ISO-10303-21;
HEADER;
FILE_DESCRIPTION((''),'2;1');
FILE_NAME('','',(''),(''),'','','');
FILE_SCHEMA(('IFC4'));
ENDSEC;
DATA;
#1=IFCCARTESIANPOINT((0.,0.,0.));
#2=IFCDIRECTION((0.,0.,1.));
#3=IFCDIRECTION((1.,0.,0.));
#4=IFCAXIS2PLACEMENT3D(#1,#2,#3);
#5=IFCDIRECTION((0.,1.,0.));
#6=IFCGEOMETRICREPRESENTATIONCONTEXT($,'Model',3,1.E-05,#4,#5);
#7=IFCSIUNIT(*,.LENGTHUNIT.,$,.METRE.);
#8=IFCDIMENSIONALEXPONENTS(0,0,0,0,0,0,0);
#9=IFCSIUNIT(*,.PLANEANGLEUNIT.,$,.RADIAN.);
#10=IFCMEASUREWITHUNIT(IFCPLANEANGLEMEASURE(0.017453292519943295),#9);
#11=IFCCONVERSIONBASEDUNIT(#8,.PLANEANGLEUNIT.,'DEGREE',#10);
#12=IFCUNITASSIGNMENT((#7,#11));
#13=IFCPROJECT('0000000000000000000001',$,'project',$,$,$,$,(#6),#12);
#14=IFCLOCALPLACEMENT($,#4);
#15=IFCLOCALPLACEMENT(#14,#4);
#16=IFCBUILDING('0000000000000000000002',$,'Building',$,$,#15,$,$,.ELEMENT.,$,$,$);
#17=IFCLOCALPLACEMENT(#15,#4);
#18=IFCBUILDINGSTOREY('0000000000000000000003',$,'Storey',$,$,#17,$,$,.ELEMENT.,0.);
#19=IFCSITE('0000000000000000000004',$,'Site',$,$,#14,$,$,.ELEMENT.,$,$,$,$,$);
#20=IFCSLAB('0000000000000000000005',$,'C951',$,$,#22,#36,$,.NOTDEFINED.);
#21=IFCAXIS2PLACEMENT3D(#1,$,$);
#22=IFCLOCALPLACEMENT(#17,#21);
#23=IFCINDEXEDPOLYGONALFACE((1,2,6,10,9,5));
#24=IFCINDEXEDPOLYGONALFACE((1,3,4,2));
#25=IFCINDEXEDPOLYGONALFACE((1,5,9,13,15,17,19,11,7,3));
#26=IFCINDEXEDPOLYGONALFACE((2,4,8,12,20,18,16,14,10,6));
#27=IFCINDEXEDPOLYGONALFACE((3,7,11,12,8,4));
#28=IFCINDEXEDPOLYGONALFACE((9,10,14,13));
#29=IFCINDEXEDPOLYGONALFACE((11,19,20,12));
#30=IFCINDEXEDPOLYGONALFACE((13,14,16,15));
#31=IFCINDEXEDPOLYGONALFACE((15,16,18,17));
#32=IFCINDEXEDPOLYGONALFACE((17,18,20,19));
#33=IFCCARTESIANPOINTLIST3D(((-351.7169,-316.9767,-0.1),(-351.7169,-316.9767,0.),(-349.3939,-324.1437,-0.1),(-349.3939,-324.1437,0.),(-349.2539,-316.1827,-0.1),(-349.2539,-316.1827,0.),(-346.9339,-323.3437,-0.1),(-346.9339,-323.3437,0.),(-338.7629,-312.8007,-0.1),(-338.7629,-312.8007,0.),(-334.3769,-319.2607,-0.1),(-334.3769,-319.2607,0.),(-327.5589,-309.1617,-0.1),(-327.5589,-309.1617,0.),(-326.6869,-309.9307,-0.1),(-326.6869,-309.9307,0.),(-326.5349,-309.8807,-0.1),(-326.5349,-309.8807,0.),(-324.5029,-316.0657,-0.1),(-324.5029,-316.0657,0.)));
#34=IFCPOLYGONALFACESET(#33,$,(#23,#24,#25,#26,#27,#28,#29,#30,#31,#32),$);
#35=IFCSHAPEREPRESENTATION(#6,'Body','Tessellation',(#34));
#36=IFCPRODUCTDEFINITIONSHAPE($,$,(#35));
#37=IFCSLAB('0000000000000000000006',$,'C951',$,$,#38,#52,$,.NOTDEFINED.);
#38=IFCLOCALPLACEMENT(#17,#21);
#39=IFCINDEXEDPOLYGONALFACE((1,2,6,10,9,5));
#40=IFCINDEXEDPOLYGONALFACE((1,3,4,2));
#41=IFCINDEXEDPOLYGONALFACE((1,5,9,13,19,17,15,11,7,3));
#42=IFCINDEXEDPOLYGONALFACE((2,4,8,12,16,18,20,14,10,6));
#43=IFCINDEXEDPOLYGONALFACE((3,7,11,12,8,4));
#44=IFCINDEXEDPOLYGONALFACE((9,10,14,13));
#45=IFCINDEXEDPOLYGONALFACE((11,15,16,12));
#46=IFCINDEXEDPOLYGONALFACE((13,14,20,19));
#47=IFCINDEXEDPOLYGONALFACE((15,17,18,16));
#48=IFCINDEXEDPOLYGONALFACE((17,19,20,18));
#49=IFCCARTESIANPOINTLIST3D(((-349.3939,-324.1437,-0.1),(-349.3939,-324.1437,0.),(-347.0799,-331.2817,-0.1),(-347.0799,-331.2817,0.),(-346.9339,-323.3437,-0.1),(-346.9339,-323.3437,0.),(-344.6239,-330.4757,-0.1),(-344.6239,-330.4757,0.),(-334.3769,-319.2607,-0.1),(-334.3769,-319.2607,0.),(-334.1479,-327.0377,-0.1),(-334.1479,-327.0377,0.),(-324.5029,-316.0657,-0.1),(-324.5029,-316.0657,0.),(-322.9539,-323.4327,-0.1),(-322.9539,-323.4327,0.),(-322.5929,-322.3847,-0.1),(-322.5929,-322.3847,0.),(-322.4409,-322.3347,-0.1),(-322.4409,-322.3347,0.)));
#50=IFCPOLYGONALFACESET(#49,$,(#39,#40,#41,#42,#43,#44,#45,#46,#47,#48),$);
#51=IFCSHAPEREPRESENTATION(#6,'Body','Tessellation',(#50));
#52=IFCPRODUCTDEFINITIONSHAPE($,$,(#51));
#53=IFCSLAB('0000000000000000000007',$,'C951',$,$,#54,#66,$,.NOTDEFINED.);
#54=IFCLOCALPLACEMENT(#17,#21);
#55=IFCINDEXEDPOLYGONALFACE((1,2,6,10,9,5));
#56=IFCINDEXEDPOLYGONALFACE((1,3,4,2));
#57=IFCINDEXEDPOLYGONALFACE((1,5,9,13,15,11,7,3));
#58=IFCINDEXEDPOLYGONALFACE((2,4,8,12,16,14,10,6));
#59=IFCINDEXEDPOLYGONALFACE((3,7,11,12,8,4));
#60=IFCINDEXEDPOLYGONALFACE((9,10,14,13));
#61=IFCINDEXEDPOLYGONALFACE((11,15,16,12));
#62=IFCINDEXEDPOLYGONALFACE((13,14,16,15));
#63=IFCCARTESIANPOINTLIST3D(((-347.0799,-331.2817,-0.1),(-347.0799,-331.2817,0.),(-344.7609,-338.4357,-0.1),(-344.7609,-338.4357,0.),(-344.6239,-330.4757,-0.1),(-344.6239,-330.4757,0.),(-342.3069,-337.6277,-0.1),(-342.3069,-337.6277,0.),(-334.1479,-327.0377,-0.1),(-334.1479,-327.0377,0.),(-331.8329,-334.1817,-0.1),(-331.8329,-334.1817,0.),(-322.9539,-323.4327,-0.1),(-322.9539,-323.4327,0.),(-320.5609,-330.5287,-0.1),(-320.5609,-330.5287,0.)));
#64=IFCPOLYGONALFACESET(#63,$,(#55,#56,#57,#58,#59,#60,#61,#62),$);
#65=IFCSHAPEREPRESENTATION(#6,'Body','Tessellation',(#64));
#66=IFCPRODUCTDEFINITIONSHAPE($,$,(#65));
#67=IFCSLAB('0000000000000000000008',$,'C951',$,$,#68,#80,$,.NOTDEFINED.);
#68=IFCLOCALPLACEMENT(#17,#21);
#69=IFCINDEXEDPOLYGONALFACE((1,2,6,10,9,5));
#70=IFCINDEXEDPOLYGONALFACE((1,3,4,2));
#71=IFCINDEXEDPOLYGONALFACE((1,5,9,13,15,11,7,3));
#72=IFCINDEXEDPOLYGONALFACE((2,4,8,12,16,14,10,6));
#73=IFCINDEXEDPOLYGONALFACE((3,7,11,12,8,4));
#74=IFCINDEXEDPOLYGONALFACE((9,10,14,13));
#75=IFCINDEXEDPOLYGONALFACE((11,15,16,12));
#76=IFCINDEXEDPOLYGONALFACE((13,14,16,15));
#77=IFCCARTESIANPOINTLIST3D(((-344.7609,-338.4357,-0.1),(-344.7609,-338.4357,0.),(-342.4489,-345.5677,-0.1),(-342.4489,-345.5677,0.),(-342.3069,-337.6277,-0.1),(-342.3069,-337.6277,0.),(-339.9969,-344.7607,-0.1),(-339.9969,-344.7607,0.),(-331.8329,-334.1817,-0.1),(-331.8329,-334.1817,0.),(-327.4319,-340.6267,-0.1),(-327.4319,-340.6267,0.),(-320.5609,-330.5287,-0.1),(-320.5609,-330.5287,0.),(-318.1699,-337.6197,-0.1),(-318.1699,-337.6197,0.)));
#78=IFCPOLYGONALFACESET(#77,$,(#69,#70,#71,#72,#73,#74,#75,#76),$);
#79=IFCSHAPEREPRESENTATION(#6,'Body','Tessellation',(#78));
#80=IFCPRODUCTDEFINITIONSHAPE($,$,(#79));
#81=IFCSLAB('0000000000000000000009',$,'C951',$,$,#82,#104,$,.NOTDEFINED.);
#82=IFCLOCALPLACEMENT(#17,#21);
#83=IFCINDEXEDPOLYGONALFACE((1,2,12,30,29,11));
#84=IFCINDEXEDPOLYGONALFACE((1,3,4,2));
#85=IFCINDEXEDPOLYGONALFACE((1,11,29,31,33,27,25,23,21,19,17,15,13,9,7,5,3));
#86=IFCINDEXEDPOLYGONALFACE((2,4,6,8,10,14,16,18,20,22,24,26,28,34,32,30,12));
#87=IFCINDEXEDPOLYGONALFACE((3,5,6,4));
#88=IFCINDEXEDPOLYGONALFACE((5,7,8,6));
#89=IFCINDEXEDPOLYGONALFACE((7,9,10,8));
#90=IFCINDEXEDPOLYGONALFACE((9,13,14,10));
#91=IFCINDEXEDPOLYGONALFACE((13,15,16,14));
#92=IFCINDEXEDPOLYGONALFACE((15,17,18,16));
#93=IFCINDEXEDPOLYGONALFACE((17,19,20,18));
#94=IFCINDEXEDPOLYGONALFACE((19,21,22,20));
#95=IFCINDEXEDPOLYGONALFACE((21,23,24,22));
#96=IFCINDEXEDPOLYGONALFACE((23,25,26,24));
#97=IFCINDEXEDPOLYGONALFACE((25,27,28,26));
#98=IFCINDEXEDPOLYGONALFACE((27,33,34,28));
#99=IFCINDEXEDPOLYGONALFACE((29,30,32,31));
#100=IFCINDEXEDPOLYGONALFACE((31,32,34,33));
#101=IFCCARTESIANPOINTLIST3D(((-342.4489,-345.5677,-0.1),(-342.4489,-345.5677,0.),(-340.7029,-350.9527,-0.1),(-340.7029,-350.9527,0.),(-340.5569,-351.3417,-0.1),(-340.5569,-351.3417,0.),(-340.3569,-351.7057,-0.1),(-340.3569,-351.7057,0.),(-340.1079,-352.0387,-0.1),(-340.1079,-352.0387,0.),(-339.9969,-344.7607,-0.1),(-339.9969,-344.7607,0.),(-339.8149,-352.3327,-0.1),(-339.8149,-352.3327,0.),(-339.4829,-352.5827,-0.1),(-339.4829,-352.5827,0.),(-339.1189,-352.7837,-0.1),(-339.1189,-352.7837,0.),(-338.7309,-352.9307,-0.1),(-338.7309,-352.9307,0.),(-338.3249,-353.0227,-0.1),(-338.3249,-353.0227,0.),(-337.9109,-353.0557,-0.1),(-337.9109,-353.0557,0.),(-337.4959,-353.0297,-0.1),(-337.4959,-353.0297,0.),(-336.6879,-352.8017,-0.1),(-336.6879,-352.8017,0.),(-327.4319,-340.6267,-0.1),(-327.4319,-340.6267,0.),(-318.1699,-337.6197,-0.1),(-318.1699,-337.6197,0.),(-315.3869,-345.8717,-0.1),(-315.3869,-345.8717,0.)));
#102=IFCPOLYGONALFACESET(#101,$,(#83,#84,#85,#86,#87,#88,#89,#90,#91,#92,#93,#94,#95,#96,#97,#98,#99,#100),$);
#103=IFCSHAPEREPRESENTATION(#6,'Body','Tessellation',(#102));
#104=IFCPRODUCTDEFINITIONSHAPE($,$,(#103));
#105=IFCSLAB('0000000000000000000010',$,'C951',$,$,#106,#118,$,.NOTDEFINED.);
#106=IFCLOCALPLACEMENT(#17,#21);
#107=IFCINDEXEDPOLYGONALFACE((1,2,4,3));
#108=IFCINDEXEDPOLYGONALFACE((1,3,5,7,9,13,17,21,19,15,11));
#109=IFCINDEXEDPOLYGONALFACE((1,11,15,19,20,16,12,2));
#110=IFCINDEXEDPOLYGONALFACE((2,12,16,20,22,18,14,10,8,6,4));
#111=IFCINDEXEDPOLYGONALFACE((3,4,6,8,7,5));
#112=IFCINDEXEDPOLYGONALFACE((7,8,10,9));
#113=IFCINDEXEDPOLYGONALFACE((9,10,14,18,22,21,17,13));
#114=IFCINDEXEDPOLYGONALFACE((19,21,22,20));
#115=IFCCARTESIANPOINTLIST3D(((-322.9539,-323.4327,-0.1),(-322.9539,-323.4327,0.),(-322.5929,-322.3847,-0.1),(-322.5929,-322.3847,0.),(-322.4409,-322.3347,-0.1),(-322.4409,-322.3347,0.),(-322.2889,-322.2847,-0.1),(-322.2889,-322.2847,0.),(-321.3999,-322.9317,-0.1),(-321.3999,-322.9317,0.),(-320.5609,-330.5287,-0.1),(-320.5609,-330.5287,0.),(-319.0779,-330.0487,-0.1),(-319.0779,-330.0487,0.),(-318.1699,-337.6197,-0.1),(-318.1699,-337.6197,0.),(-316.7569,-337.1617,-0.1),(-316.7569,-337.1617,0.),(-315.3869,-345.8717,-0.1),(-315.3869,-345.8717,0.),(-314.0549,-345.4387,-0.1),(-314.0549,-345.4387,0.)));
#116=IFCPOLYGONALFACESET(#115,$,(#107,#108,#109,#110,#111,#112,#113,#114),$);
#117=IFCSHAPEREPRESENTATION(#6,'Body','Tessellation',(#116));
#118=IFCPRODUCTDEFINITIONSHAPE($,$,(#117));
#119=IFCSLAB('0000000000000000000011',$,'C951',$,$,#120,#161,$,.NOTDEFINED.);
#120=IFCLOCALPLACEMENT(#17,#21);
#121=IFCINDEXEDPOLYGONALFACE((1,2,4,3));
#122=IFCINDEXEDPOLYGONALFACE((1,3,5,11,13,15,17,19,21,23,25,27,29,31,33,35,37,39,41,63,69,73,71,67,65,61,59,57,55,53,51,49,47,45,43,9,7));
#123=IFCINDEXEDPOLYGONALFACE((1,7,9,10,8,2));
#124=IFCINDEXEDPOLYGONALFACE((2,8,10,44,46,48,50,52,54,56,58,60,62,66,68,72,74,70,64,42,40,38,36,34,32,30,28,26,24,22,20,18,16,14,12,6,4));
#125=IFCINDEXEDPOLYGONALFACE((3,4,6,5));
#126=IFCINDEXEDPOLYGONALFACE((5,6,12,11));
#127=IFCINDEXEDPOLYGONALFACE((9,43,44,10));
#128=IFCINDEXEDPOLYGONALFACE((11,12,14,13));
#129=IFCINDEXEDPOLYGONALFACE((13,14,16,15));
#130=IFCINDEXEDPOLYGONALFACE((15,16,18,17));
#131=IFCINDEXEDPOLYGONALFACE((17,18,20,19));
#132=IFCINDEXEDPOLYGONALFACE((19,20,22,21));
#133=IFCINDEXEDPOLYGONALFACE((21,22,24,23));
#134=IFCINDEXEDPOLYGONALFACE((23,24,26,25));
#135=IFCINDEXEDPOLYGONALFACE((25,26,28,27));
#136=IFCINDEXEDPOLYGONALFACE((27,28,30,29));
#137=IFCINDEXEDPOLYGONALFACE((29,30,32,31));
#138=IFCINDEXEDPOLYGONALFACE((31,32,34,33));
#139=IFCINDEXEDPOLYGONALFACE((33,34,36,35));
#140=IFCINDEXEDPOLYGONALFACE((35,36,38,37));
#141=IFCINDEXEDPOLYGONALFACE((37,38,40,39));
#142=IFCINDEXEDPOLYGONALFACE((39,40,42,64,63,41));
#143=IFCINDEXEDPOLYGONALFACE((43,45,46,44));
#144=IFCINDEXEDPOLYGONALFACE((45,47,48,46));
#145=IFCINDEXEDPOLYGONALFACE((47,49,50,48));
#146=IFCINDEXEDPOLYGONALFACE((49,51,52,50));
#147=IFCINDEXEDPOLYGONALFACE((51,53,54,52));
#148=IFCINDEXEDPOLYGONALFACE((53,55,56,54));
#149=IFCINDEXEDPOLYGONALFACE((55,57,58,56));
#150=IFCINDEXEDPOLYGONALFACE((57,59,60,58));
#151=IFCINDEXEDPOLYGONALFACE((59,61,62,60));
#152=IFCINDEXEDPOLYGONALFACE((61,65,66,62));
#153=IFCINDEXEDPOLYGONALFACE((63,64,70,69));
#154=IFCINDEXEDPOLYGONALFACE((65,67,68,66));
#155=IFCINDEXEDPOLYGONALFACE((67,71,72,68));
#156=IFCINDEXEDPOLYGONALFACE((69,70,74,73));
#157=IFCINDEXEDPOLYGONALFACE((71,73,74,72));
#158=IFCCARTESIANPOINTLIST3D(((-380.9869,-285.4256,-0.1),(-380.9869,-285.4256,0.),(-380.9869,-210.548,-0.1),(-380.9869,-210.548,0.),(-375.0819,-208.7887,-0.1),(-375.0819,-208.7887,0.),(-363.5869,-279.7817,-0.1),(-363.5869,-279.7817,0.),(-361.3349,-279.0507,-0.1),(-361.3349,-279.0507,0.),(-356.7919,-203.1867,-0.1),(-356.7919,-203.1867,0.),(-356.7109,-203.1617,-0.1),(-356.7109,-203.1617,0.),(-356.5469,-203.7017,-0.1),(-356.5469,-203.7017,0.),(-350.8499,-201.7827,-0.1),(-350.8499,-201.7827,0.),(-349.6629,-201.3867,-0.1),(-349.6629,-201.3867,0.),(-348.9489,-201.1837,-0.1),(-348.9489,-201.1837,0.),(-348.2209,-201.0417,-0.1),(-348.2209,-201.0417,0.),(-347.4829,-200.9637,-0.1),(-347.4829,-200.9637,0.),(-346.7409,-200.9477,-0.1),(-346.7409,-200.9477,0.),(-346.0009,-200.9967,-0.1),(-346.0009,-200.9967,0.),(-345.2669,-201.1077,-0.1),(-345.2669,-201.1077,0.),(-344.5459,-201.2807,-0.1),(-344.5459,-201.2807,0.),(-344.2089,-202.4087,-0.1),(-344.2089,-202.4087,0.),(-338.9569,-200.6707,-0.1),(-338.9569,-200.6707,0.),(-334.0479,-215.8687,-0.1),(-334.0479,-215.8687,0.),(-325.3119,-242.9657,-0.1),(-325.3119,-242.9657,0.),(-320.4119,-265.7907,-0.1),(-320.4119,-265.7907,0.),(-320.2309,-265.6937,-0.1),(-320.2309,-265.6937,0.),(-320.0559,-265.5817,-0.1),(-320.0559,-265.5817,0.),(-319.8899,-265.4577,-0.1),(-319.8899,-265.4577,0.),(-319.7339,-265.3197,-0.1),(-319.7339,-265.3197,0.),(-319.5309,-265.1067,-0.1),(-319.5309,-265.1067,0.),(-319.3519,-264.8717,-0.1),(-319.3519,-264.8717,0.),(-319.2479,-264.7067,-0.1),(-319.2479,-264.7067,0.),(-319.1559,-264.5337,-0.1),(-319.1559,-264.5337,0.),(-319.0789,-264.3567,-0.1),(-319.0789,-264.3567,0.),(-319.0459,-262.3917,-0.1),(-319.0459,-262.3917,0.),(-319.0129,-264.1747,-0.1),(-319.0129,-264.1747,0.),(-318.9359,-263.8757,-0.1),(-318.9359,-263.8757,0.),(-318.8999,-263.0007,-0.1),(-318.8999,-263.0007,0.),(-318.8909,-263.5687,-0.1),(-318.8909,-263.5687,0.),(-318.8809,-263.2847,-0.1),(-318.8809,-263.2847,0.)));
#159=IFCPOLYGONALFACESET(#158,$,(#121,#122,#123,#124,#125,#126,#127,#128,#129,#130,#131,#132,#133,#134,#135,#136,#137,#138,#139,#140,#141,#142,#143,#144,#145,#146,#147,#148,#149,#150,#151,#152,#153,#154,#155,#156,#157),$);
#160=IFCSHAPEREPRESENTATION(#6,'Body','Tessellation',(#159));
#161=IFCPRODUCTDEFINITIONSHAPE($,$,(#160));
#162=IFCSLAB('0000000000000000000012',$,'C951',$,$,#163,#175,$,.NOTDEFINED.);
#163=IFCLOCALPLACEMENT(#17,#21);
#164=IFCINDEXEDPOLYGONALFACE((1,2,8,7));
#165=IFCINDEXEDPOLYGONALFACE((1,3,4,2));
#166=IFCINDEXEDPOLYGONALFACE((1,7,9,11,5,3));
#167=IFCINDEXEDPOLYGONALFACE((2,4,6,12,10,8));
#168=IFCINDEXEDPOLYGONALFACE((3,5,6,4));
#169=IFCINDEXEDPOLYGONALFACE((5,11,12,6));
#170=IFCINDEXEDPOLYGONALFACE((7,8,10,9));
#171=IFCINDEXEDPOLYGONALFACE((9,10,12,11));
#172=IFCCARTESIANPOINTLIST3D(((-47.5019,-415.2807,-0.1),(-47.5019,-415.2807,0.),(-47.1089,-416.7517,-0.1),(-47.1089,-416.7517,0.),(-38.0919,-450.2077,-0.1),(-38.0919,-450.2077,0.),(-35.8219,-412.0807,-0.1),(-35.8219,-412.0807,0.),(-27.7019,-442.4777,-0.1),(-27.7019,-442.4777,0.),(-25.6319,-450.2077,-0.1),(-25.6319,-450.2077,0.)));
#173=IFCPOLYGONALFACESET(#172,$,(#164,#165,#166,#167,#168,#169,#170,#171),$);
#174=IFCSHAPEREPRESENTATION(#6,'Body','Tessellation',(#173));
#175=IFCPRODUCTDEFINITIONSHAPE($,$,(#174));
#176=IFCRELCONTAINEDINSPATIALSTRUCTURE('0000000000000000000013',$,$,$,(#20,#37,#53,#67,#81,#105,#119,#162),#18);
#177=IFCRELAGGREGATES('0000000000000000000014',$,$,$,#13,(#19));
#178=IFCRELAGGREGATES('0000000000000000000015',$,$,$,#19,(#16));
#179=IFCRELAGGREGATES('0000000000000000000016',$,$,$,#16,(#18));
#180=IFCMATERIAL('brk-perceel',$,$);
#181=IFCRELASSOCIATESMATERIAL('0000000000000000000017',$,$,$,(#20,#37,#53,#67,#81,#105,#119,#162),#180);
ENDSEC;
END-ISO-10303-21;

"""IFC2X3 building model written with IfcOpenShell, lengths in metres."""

from ifc_helpers import new_model, entity, si_unit, converted_unit, direction, frame, origin_with_axes, place, context, project, spatial, polyline, outline, extrude, material, element, save


model = new_model("IFC2X3")

# Units and contexts
model_context = context("Model", 3, precision=1e-05, world=origin_with_axes(), true_north=direction((0.0, 1.0, 0.0)))
ifc_project = project(units=[si_unit("LENGTHUNIT", "METRE"), converted_unit("PLANEANGLEUNIT", "DEGREE", entity("IfcPlaneAngleMeasure", 0.017453292519943295), si_unit("PLANEANGLEUNIT", "RADIAN"), dimensions=[0, 0, 0, 0, 0, 0, 0])], contexts=[model_context])

# Site, building, storey
site_placement = place(None, origin_with_axes())
site = spatial("IfcSite", under=ifc_project, at=site_placement, Name="Site", CompositionType="ELEMENT")
building_placement = place(site_placement, origin_with_axes())
building = spatial("IfcBuilding", under=site, at=building_placement, Name="Building", CompositionType="ELEMENT")
storey_placement = place(building_placement, origin_with_axes())
storey = spatial("IfcBuildingStorey", under=building, at=storey_placement, Name="Storey", CompositionType="ELEMENT", Elevation=0.0)

# Slabs
ifc_material = material(Name="brk-perceel")
slab_1_placement = place(storey_placement, frame((0.0, 0.0, -0.1), z_axis=(0.0, 0.0, 1.0), x_axis=(1.0, 0.0, 0.0)))
element("IfcSlab", 1, at=slab_1_placement, inside=storey, material=ifc_material, Name="C951", PredefinedType="NOTDEFINED", context=model_context, shape_type="SweptSolid", body=[
    extrude(outline(polyline([(-349.3939, -324.1437), (-351.7169, -316.9767), (-349.2539, -316.1827), (-338.7629, -312.8007), (-327.5589, -309.1617), (-326.6869, -309.9307), (-326.5349, -309.8807), (-324.5029, -316.0657), (-334.3769, -319.2607), (-346.9339, -323.3437), (-349.3939, -324.1437)])), origin_with_axes(), (0.0, 0.0, 1.0), 0.1),
])
slab_2_placement = place(storey_placement, frame((0.0, 0.0, -0.1), z_axis=(0.0, 0.0, 1.0), x_axis=(1.0, 0.0, 0.0)))
element("IfcSlab", 2, at=slab_2_placement, inside=storey, material=ifc_material, Name="C951", PredefinedType="NOTDEFINED", context=model_context, shape_type="SweptSolid", body=[
    extrude(outline(polyline([(-347.0799, -331.2817), (-349.3939, -324.1437), (-346.9339, -323.3437), (-334.3769, -319.2607), (-324.5029, -316.0657), (-322.4409, -322.3347), (-322.5929, -322.3847), (-322.9539, -323.4327), (-334.1479, -327.0377), (-344.6239, -330.4757), (-347.0799, -331.2817)])), origin_with_axes(), (0.0, 0.0, 1.0), 0.1),
])
slab_3_placement = place(storey_placement, frame((0.0, 0.0, -0.1), z_axis=(0.0, 0.0, 1.0), x_axis=(1.0, 0.0, 0.0)))
element("IfcSlab", 3, at=slab_3_placement, inside=storey, material=ifc_material, Name="C951", PredefinedType="NOTDEFINED", context=model_context, shape_type="SweptSolid", body=[
    extrude(outline(polyline([(-344.7609, -338.4357), (-347.0799, -331.2817), (-344.6239, -330.4757), (-334.1479, -327.0377), (-322.9539, -323.4327), (-320.5609, -330.5287), (-331.8329, -334.1817), (-342.3069, -337.6277), (-344.7609, -338.4357)])), origin_with_axes(), (0.0, 0.0, 1.0), 0.1),
])
slab_4_placement = place(storey_placement, frame((0.0, 0.0, -0.1), z_axis=(0.0, 0.0, 1.0), x_axis=(1.0, 0.0, 0.0)))
element("IfcSlab", 4, at=slab_4_placement, inside=storey, material=ifc_material, Name="C951", PredefinedType="NOTDEFINED", context=model_context, shape_type="SweptSolid", body=[
    extrude(outline(polyline([(-342.4489, -345.5677), (-344.7609, -338.4357), (-342.3069, -337.6277), (-331.8329, -334.1817), (-320.5609, -330.5287), (-318.1699, -337.6197), (-327.4319, -340.6267), (-339.9969, -344.7607), (-342.4489, -345.5677)])), origin_with_axes(), (0.0, 0.0, 1.0), 0.1),
])
slab_5_placement = place(storey_placement, frame((0.0, 0.0, -0.1), z_axis=(0.0, 0.0, 1.0), x_axis=(1.0, 0.0, 0.0)))
element("IfcSlab", 5, at=slab_5_placement, inside=storey, material=ifc_material, Name="C951", PredefinedType="NOTDEFINED", context=model_context, shape_type="SweptSolid", body=[
    extrude(outline(polyline([(-327.4319, -340.6267), (-318.1699, -337.6197), (-315.3869, -345.8717), (-336.6879, -352.8017), (-337.4959, -353.0297), (-337.9109, -353.0557), (-338.3249, -353.0227), (-338.7309, -352.9307), (-339.1189, -352.7837), (-339.4829, -352.5827), (-339.8149, -352.3327), (-340.1079, -352.0387), (-340.3569, -351.7057), (-340.5569, -351.3417), (-340.7029, -350.9527), (-342.4489, -345.5677), (-339.9969, -344.7607), (-327.4319, -340.6267)])), origin_with_axes(), (0.0, 0.0, 1.0), 0.1),
])
slab_6_placement = place(storey_placement, frame((0.0, 0.0, -0.1), z_axis=(0.0, 0.0, 1.0), x_axis=(1.0, 0.0, 0.0)))
element("IfcSlab", 6, at=slab_6_placement, inside=storey, material=ifc_material, Name="C951", PredefinedType="NOTDEFINED", context=model_context, shape_type="SweptSolid", body=[
    extrude(outline(polyline([(-314.0549, -345.4387), (-315.3869, -345.8717), (-318.1699, -337.6197), (-320.5609, -330.5287), (-322.9539, -323.4327), (-322.5929, -322.3847), (-322.4409, -322.3347), (-322.2889, -322.2847), (-321.3999, -322.9317), (-319.0779, -330.0487), (-316.7569, -337.1617), (-314.0549, -345.4387)])), origin_with_axes(), (0.0, 0.0, 1.0), 0.1),
])
slab_7_placement = place(storey_placement, frame((0.0, 0.0, -0.1), z_axis=(0.0, 0.0, 1.0), x_axis=(1.0, 0.0, 0.0)))
element("IfcSlab", 7, at=slab_7_placement, inside=storey, material=ifc_material, Name="C951", PredefinedType="NOTDEFINED", context=model_context, shape_type="SweptSolid", body=[
    extrude(outline(polyline([(-375.0819, -208.7887), (-356.7919, -203.1867), (-356.7109, -203.1617), (-356.5469, -203.7017), (-350.8499, -201.7827), (-349.6629, -201.3867), (-348.9489, -201.1837), (-348.2209, -201.0417), (-347.4829, -200.9637), (-346.7409, -200.9477), (-346.0009, -200.9967), (-345.2669, -201.1077), (-344.5459, -201.2807), (-344.2089, -202.4087), (-338.9569, -200.6707), (-334.0479, -215.8687), (-325.3119, -242.9657), (-319.0459, -262.3917), (-318.8999, -263.0007), (-318.8809, -263.2847), (-318.8909, -263.5687), (-318.9359, -263.8757), (-319.0129, -264.1747), (-319.0789, -264.3567), (-319.1559, -264.5337), (-319.2479, -264.7067), (-319.3519, -264.8717), (-319.5309, -265.1067), (-319.7339, -265.3197), (-319.8899, -265.4577), (-320.0559, -265.5817), (-320.2309, -265.6937), (-320.4119, -265.7907), (-361.3349, -279.0507), (-363.5869, -279.7817), (-380.9869, -285.4256), (-380.9869, -210.548), (-375.0819, -208.7887)])), origin_with_axes(), (0.0, 0.0, 1.0), 0.1),
])
slab_8_placement = place(storey_placement, frame((0.0, 0.0, -0.1), z_axis=(0.0, 0.0, 1.0), x_axis=(1.0, 0.0, 0.0)))
element("IfcSlab", 8, at=slab_8_placement, inside=storey, material=ifc_material, Name="C951", PredefinedType="NOTDEFINED", context=model_context, shape_type="SweptSolid", body=[
    extrude(outline(polyline([(-47.1089, -416.7517), (-47.5019, -415.2807), (-35.8219, -412.0807), (-27.7019, -442.4777), (-25.6319, -450.2077), (-38.0919, -450.2077), (-47.1089, -416.7517)])), origin_with_axes(), (0.0, 0.0, 1.0), 0.1),
])

save(model, "model.ifc")
